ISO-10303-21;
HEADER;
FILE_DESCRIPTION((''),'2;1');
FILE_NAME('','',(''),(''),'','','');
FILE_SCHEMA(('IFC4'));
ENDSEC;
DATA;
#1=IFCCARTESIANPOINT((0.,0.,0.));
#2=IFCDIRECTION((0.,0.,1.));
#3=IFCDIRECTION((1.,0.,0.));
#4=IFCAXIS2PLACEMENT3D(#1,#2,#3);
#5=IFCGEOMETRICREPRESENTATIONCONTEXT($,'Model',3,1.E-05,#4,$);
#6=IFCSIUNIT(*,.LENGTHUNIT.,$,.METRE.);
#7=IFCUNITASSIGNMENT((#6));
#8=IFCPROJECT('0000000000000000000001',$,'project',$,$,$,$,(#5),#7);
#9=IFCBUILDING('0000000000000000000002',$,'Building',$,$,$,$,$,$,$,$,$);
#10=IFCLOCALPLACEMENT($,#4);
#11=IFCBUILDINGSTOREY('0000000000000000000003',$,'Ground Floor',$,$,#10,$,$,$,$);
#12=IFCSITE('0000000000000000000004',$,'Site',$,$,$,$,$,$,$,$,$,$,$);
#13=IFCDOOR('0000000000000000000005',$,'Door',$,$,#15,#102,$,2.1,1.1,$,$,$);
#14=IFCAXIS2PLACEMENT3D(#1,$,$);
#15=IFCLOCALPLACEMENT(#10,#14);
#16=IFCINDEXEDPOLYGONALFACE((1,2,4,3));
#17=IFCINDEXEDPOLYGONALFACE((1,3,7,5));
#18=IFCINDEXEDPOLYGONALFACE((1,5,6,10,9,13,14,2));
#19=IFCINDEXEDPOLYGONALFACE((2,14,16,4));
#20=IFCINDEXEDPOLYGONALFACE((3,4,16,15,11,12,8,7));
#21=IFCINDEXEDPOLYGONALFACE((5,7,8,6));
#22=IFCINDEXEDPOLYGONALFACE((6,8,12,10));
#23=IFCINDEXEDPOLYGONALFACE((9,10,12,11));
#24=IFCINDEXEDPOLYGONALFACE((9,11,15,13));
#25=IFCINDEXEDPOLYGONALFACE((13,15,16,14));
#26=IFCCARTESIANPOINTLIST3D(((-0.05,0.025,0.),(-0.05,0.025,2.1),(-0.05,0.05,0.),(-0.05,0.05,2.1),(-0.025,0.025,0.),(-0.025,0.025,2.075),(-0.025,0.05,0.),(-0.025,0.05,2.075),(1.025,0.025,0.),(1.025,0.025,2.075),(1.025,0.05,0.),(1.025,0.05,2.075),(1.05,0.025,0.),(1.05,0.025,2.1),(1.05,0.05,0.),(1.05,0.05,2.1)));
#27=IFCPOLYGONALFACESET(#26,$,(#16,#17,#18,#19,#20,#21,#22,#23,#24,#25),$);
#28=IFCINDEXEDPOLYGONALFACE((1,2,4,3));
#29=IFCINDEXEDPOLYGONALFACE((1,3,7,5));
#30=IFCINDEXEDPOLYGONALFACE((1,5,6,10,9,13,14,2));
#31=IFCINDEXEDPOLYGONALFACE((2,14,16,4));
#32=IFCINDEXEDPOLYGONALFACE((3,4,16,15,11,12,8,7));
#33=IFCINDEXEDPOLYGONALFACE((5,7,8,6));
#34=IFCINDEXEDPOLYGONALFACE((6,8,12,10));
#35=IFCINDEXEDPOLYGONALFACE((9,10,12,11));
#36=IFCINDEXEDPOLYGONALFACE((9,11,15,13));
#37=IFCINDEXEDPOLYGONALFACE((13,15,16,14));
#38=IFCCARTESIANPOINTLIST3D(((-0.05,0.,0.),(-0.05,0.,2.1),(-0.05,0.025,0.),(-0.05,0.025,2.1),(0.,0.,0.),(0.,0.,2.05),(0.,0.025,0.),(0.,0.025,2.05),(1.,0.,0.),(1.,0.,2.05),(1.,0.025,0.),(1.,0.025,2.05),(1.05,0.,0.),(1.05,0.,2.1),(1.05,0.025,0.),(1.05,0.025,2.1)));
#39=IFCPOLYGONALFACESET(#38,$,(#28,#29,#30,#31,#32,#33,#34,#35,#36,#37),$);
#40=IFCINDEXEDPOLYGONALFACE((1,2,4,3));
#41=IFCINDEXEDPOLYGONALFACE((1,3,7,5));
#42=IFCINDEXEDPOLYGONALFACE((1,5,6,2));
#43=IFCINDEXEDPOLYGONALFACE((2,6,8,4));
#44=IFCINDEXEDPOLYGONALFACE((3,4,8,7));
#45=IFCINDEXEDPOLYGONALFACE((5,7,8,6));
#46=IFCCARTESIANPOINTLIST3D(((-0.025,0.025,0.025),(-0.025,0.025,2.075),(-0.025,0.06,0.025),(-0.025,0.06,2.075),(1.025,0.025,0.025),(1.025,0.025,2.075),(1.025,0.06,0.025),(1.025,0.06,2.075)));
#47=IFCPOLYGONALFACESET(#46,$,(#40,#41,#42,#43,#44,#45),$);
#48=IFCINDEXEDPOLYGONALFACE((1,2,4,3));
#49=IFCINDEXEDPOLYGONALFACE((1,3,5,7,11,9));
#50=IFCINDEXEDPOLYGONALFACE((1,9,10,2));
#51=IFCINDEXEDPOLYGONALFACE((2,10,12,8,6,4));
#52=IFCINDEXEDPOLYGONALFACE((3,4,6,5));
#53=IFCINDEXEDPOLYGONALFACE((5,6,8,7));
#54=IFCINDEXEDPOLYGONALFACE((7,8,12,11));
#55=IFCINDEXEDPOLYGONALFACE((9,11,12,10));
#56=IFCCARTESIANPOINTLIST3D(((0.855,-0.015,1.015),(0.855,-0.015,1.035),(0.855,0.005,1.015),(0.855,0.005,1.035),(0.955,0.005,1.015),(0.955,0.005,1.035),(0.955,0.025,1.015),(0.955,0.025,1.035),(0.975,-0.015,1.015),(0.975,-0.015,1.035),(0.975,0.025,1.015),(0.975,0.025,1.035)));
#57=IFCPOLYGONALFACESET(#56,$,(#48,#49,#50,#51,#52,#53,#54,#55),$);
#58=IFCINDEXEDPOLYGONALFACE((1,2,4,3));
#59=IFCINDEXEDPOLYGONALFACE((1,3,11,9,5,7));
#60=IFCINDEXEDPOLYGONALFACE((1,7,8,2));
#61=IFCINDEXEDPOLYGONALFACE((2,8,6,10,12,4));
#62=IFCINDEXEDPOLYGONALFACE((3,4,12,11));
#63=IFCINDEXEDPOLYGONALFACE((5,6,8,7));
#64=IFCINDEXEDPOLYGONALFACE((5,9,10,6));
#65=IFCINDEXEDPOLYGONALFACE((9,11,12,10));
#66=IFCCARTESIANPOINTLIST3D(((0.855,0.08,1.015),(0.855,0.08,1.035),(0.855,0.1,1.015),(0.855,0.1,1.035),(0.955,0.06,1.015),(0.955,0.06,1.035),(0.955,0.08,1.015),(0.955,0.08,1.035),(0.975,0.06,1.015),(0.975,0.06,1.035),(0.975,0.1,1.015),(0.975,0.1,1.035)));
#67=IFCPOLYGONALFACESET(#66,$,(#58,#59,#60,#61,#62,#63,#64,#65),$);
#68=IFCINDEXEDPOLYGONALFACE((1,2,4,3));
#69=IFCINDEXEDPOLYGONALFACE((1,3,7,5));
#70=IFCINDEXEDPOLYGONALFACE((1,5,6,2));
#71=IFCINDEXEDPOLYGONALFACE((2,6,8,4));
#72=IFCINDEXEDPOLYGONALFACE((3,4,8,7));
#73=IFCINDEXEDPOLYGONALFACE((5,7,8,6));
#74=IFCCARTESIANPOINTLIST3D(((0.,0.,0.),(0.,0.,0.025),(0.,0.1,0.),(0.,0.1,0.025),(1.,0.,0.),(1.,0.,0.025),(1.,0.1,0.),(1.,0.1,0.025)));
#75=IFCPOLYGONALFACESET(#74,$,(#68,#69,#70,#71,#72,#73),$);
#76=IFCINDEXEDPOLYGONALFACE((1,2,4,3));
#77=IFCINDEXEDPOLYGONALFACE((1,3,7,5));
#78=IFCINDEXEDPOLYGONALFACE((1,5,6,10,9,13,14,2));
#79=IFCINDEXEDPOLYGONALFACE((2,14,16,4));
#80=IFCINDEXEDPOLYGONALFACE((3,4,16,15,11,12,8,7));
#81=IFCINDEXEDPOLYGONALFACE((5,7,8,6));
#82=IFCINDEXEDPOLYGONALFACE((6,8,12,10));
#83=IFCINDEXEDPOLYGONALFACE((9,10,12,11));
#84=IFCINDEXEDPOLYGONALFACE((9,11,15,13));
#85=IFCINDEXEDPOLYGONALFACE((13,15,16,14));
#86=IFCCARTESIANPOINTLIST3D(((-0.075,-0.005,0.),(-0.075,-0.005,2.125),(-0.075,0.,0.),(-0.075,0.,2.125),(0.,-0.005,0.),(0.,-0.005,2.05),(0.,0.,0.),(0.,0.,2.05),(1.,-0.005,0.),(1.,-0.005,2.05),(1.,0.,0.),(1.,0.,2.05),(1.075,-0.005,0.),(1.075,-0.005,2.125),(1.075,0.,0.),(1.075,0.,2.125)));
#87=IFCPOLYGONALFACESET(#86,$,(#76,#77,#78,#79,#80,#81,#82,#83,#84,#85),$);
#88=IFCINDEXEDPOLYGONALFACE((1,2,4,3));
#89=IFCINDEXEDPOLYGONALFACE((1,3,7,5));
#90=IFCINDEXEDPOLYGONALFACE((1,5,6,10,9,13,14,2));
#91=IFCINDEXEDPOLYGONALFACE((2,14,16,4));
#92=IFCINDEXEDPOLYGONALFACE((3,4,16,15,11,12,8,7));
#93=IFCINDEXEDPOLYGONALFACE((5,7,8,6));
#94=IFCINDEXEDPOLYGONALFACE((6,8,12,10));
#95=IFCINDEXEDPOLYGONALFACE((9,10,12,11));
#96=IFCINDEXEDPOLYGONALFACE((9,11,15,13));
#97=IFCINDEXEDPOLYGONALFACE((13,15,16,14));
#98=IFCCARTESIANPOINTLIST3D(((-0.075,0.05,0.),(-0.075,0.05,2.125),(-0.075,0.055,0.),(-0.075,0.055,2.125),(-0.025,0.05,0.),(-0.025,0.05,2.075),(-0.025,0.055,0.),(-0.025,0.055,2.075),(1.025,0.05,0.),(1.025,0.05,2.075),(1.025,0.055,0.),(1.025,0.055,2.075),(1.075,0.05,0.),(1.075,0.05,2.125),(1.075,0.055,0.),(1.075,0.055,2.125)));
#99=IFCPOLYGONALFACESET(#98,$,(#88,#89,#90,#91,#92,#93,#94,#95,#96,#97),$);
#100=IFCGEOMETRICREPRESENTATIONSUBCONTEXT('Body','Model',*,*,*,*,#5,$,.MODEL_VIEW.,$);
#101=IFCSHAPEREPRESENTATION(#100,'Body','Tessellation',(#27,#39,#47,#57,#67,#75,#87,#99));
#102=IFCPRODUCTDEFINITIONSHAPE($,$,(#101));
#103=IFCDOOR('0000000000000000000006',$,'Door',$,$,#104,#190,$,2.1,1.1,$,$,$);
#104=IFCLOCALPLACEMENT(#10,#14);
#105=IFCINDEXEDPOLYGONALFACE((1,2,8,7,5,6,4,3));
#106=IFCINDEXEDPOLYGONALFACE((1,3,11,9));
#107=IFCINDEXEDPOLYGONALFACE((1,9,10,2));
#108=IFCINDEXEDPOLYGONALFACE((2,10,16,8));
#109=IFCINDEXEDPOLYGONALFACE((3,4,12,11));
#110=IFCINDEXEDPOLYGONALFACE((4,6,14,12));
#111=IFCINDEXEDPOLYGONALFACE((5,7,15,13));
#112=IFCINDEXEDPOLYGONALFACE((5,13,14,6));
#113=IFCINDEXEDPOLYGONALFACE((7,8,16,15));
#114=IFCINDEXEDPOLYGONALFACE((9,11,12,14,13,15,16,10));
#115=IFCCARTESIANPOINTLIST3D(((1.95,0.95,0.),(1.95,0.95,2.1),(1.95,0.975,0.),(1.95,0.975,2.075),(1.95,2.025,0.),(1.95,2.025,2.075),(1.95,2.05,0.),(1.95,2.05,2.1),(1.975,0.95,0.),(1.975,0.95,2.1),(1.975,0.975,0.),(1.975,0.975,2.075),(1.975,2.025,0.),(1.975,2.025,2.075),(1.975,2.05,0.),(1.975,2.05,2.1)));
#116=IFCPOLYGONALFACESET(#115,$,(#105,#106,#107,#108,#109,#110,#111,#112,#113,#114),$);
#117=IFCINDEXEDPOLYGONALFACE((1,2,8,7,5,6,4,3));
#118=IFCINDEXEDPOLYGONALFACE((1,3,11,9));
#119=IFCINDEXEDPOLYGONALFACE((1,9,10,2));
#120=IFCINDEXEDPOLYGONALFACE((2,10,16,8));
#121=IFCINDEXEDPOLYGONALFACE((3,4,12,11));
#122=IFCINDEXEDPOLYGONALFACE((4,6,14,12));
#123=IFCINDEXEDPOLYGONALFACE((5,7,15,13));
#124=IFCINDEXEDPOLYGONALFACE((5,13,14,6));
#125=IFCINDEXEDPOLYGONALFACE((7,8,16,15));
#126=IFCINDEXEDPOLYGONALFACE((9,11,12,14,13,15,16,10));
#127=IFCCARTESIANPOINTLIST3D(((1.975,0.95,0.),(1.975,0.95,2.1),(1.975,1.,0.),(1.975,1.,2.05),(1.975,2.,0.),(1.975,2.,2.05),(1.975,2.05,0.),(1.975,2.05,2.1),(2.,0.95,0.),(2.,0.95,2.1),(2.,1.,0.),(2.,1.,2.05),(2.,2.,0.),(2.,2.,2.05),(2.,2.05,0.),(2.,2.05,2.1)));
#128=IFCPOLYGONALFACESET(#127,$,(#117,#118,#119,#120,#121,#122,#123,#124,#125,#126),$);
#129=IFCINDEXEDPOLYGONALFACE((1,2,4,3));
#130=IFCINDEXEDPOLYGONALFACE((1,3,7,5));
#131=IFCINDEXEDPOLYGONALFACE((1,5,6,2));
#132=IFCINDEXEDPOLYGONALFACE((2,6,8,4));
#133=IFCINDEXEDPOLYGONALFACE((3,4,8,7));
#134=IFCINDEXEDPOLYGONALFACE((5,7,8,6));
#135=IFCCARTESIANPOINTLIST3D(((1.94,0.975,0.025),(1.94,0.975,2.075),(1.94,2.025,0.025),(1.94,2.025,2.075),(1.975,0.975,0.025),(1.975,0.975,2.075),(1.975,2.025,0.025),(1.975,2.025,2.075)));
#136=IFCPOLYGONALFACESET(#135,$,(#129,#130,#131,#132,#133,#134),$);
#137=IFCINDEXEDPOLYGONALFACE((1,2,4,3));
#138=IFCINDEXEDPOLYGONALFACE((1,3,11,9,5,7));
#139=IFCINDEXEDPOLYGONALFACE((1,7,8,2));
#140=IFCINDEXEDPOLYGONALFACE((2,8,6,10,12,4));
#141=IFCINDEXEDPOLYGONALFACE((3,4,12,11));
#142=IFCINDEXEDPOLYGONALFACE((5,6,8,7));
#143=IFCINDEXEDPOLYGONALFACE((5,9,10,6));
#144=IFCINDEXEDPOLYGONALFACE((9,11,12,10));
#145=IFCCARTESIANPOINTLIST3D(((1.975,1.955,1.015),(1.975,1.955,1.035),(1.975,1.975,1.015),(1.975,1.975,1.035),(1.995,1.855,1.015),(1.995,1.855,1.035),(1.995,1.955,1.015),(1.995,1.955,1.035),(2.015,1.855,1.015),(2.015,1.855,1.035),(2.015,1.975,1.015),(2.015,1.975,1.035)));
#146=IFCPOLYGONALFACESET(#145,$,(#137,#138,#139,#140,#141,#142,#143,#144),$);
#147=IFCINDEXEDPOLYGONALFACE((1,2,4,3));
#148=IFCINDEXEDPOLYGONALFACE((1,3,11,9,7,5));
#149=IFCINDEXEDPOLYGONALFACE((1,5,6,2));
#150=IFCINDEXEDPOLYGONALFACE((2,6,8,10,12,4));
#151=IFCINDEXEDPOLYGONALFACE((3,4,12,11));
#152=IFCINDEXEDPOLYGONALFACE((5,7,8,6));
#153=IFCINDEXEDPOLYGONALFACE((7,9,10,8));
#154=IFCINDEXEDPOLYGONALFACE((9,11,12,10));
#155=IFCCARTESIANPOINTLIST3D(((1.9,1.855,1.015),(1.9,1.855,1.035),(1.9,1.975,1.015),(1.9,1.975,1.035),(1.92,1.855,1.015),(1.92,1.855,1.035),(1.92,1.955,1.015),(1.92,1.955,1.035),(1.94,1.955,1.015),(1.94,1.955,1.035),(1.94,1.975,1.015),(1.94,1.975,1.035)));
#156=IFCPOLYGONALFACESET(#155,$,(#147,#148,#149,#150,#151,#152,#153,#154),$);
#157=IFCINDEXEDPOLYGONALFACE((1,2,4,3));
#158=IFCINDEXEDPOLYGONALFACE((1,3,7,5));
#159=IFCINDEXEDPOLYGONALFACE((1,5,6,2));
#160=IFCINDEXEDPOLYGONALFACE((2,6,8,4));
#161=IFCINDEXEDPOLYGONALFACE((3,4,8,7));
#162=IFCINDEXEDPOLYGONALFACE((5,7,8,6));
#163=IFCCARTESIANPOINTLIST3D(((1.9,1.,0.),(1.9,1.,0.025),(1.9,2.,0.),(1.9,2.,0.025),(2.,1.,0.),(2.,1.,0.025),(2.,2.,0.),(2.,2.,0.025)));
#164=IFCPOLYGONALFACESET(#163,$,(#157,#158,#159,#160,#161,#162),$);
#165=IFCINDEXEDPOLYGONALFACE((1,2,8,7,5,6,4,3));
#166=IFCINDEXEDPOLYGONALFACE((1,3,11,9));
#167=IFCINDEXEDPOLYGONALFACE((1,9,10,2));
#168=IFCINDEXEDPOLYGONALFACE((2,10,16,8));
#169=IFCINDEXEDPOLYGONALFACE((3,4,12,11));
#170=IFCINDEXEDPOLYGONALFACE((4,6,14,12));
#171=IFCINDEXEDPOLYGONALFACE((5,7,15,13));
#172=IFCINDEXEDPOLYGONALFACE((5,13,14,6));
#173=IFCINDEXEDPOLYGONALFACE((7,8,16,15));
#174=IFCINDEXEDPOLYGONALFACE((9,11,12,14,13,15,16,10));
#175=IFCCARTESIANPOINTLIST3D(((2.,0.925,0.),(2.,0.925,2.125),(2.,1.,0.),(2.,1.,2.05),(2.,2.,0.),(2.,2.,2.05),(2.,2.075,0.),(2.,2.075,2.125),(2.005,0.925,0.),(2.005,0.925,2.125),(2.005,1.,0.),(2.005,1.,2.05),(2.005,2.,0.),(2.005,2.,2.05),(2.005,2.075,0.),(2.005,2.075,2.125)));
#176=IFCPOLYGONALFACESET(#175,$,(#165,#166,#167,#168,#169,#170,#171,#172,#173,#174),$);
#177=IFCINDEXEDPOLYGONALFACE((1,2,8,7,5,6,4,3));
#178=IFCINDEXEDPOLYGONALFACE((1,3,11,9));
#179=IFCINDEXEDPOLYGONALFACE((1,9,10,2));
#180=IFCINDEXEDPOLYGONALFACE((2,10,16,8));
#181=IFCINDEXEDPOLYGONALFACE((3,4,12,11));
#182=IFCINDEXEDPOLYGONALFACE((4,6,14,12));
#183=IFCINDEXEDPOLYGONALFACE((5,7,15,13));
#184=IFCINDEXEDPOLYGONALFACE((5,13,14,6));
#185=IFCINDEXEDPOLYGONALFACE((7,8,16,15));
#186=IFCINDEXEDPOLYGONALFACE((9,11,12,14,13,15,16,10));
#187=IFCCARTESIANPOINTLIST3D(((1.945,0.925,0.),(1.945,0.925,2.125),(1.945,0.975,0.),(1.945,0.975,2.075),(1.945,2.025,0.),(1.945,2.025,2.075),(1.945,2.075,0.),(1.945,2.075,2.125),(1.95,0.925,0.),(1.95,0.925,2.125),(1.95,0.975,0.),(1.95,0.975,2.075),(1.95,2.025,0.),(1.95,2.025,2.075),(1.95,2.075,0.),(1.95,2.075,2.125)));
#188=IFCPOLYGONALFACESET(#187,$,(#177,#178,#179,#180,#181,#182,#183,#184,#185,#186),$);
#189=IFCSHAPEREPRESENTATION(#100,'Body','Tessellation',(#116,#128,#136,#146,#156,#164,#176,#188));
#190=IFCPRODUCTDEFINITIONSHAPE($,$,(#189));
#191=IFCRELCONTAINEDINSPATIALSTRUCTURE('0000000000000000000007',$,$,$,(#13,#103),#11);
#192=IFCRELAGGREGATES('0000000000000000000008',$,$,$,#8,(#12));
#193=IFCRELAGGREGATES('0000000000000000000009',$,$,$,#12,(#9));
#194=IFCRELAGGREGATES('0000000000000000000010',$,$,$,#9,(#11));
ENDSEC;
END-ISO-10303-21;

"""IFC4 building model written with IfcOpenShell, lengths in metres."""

from ifc_helpers import new_model, si_unit, frame, origin_with_axes, place, context, subcontext, project, spatial, line, indexed_curve, outline, extrude, element, save


model = new_model("IFC4")

# Units and contexts
model_context = context("Model", 3, precision=1e-05, world=origin_with_axes())
body_context = subcontext(model_context, "Body", "Model", "MODEL_VIEW")
ifc_project = project(units=[si_unit("LENGTHUNIT", "METRE")], contexts=[model_context])

# Site, building, storey
site = spatial("IfcSite", under=ifc_project, Name="Site")
building = spatial("IfcBuilding", under=site, Name="Building")
storey_placement = place(None, origin_with_axes())
storey = spatial("IfcBuildingStorey", under=building, at=storey_placement, Name="Ground Floor")

# Doors
door_1_placement = place(storey_placement, frame((-0.05, 0.0, 0.0), z_axis=(0.0, 0.0, 1.0), x_axis=(1.0, 0.0, 0.0)))
element("IfcDoor", 1, at=door_1_placement, inside=storey, Name="Door", OverallHeight=2.1, OverallWidth=1.1, context=body_context, shape_type="SweptSolid", body=[
    extrude(outline(indexed_curve([(0.0, 0.0), (0.0, 2.1), (1.1, 2.1), (1.1, 0.0), (1.075, 0.0), (1.075, 2.075), (0.025, 2.075), (0.025, 0.0)], segments=[line(1, 2, 3, 4, 5, 6, 7, 8, 1)])), frame((0.0, 0.025, 0.0), z_axis=(0.0, -1.0, 0.0), x_axis=(1.0, 0.0, 0.0)), (0.0, 0.0, -1.0), 0.025),
    extrude(outline(indexed_curve([(0.0, 0.0), (0.0, 2.1), (1.1, 2.1), (1.1, 0.0), (1.05, 0.0), (1.05, 2.05), (0.05, 2.05), (0.05, 0.0)], segments=[line(1, 2, 3, 4, 5, 6, 7, 8, 1)])), frame((0.0, 0.0, 0.0), z_axis=(0.0, -1.0, 0.0), x_axis=(1.0, 0.0, 0.0)), (0.0, 0.0, -1.0), 0.025),
    extrude(outline(indexed_curve([(0.0, 0.0), (1.05, 0.0), (1.05, 0.035), (0.0, 0.035)], segments=[line(1, 2, 3, 4, 1)])), frame((0.025, 0.025, 0.025), z_axis=(0.0, 0.0, 1.0), x_axis=(1.0, 0.0, 0.0)), (0.0, 0.0, 1.0), 2.05),
    extrude(outline(indexed_curve([(0.0, 0.0), (0.0, -0.04), (-0.12, -0.04), (-0.12, -0.02), (-0.02, -0.02), (-0.02, 0.0)], segments=[line(1, 2, 3, 4, 5, 6, 1)])), frame((1.025, 0.025, 1.015), z_axis=(0.0, 0.0, 1.0), x_axis=(1.0, 0.0, 0.0)), (0.0, 0.0, 1.0), 0.02),
    extrude(outline(indexed_curve([(0.0, 0.0), (0.0, 0.04), (-0.12, 0.04), (-0.12, 0.02), (-0.02, 0.02), (-0.02, 0.0)], segments=[line(1, 2, 3, 4, 5, 6, 1)])), frame((1.025, 0.06, 1.015), z_axis=(0.0, 0.0, 1.0), x_axis=(1.0, 0.0, 0.0)), (0.0, 0.0, 1.0), 0.02),
    extrude(outline(indexed_curve([(0.0, 0.0), (1.0, 0.0), (1.0, 0.1), (0.0, 0.1)], segments=[line(1, 2, 3, 4, 1)])), frame((0.05, 0.0, 0.0), z_axis=(0.0, 0.0, 1.0), x_axis=(1.0, 0.0, 0.0)), (0.0, 0.0, 1.0), 0.025),
    extrude(outline(indexed_curve([(0.0, 0.0), (0.0, 2.125), (1.15, 2.125), (1.15, 0.0), (1.075, 0.0), (1.075, 2.05), (0.075, 2.05), (0.075, 0.0)], segments=[line(1, 2, 3, 4, 5, 6, 7, 8, 1)])), frame((-0.025, -0.005, 0.0), z_axis=(0.0, -1.0, 0.0), x_axis=(1.0, 0.0, 0.0)), (0.0, 0.0, -1.0), 0.005),
    extrude(outline(indexed_curve([(0.0, 0.0), (0.0, 2.125), (1.15, 2.125), (1.15, 0.0), (1.1, 0.0), (1.1, 2.075), (0.05, 2.075), (0.05, 0.0)], segments=[line(1, 2, 3, 4, 5, 6, 7, 8, 1)])), frame((-0.025, 0.05, 0.0), z_axis=(0.0, -1.0, 0.0), x_axis=(1.0, 0.0, 0.0)), (0.0, 0.0, -1.0), 0.005),
])
door_2_placement = place(storey_placement, frame((2.0, 0.95, 0.0), z_axis=(0.0, 0.0, 1.0), x_axis=(0.0, 1.0, 0.0)))
element("IfcDoor", 2, at=door_2_placement, inside=storey, Name="Door", OverallHeight=2.1, OverallWidth=1.1, context=body_context, shape_type="SweptSolid", body=[
    extrude(outline(indexed_curve([(0.0, 0.0), (0.0, 2.1), (1.1, 2.1), (1.1, 0.0), (1.075, 0.0), (1.075, 2.075), (0.025, 2.075), (0.025, 0.0)], segments=[line(1, 2, 3, 4, 5, 6, 7, 8, 1)])), frame((0.0, 0.025, 0.0), z_axis=(0.0, -1.0, 0.0), x_axis=(1.0, 0.0, 0.0)), (0.0, 0.0, -1.0), 0.025),
    extrude(outline(indexed_curve([(0.0, 0.0), (0.0, 2.1), (1.1, 2.1), (1.1, 0.0), (1.05, 0.0), (1.05, 2.05), (0.05, 2.05), (0.05, 0.0)], segments=[line(1, 2, 3, 4, 5, 6, 7, 8, 1)])), frame((0.0, 0.0, 0.0), z_axis=(0.0, -1.0, 0.0), x_axis=(1.0, 0.0, 0.0)), (0.0, 0.0, -1.0), 0.025),
    extrude(outline(indexed_curve([(0.0, 0.0), (1.05, 0.0), (1.05, 0.035), (0.0, 0.035)], segments=[line(1, 2, 3, 4, 1)])), frame((0.025, 0.025, 0.025), z_axis=(0.0, 0.0, 1.0), x_axis=(1.0, 0.0, 0.0)), (0.0, 0.0, 1.0), 2.05),
    extrude(outline(indexed_curve([(0.0, 0.0), (0.0, -0.04), (-0.12, -0.04), (-0.12, -0.02), (-0.02, -0.02), (-0.02, 0.0)], segments=[line(1, 2, 3, 4, 5, 6, 1)])), frame((1.025, 0.025, 1.015), z_axis=(0.0, 0.0, 1.0), x_axis=(1.0, 0.0, 0.0)), (0.0, 0.0, 1.0), 0.02),
    extrude(outline(indexed_curve([(0.0, 0.0), (0.0, 0.04), (-0.12, 0.04), (-0.12, 0.02), (-0.02, 0.02), (-0.02, 0.0)], segments=[line(1, 2, 3, 4, 5, 6, 1)])), frame((1.025, 0.06, 1.015), z_axis=(0.0, 0.0, 1.0), x_axis=(1.0, 0.0, 0.0)), (0.0, 0.0, 1.0), 0.02),
    extrude(outline(indexed_curve([(0.0, 0.0), (1.0, 0.0), (1.0, 0.1), (0.0, 0.1)], segments=[line(1, 2, 3, 4, 1)])), frame((0.05, 0.0, 0.0), z_axis=(0.0, 0.0, 1.0), x_axis=(1.0, 0.0, 0.0)), (0.0, 0.0, 1.0), 0.025),
    extrude(outline(indexed_curve([(0.0, 0.0), (0.0, 2.125), (1.15, 2.125), (1.15, 0.0), (1.075, 0.0), (1.075, 2.05), (0.075, 2.05), (0.075, 0.0)], segments=[line(1, 2, 3, 4, 5, 6, 7, 8, 1)])), frame((-0.025, -0.005, 0.0), z_axis=(0.0, -1.0, 0.0), x_axis=(1.0, 0.0, 0.0)), (0.0, 0.0, -1.0), 0.005),
    extrude(outline(indexed_curve([(0.0, 0.0), (0.0, 2.125), (1.15, 2.125), (1.15, 0.0), (1.1, 0.0), (1.1, 2.075), (0.05, 2.075), (0.05, 0.0)], segments=[line(1, 2, 3, 4, 5, 6, 7, 8, 1)])), frame((-0.025, 0.05, 0.0), z_axis=(0.0, -1.0, 0.0), x_axis=(1.0, 0.0, 0.0)), (0.0, 0.0, -1.0), 0.005),
])

save(model, "model.ifc")
